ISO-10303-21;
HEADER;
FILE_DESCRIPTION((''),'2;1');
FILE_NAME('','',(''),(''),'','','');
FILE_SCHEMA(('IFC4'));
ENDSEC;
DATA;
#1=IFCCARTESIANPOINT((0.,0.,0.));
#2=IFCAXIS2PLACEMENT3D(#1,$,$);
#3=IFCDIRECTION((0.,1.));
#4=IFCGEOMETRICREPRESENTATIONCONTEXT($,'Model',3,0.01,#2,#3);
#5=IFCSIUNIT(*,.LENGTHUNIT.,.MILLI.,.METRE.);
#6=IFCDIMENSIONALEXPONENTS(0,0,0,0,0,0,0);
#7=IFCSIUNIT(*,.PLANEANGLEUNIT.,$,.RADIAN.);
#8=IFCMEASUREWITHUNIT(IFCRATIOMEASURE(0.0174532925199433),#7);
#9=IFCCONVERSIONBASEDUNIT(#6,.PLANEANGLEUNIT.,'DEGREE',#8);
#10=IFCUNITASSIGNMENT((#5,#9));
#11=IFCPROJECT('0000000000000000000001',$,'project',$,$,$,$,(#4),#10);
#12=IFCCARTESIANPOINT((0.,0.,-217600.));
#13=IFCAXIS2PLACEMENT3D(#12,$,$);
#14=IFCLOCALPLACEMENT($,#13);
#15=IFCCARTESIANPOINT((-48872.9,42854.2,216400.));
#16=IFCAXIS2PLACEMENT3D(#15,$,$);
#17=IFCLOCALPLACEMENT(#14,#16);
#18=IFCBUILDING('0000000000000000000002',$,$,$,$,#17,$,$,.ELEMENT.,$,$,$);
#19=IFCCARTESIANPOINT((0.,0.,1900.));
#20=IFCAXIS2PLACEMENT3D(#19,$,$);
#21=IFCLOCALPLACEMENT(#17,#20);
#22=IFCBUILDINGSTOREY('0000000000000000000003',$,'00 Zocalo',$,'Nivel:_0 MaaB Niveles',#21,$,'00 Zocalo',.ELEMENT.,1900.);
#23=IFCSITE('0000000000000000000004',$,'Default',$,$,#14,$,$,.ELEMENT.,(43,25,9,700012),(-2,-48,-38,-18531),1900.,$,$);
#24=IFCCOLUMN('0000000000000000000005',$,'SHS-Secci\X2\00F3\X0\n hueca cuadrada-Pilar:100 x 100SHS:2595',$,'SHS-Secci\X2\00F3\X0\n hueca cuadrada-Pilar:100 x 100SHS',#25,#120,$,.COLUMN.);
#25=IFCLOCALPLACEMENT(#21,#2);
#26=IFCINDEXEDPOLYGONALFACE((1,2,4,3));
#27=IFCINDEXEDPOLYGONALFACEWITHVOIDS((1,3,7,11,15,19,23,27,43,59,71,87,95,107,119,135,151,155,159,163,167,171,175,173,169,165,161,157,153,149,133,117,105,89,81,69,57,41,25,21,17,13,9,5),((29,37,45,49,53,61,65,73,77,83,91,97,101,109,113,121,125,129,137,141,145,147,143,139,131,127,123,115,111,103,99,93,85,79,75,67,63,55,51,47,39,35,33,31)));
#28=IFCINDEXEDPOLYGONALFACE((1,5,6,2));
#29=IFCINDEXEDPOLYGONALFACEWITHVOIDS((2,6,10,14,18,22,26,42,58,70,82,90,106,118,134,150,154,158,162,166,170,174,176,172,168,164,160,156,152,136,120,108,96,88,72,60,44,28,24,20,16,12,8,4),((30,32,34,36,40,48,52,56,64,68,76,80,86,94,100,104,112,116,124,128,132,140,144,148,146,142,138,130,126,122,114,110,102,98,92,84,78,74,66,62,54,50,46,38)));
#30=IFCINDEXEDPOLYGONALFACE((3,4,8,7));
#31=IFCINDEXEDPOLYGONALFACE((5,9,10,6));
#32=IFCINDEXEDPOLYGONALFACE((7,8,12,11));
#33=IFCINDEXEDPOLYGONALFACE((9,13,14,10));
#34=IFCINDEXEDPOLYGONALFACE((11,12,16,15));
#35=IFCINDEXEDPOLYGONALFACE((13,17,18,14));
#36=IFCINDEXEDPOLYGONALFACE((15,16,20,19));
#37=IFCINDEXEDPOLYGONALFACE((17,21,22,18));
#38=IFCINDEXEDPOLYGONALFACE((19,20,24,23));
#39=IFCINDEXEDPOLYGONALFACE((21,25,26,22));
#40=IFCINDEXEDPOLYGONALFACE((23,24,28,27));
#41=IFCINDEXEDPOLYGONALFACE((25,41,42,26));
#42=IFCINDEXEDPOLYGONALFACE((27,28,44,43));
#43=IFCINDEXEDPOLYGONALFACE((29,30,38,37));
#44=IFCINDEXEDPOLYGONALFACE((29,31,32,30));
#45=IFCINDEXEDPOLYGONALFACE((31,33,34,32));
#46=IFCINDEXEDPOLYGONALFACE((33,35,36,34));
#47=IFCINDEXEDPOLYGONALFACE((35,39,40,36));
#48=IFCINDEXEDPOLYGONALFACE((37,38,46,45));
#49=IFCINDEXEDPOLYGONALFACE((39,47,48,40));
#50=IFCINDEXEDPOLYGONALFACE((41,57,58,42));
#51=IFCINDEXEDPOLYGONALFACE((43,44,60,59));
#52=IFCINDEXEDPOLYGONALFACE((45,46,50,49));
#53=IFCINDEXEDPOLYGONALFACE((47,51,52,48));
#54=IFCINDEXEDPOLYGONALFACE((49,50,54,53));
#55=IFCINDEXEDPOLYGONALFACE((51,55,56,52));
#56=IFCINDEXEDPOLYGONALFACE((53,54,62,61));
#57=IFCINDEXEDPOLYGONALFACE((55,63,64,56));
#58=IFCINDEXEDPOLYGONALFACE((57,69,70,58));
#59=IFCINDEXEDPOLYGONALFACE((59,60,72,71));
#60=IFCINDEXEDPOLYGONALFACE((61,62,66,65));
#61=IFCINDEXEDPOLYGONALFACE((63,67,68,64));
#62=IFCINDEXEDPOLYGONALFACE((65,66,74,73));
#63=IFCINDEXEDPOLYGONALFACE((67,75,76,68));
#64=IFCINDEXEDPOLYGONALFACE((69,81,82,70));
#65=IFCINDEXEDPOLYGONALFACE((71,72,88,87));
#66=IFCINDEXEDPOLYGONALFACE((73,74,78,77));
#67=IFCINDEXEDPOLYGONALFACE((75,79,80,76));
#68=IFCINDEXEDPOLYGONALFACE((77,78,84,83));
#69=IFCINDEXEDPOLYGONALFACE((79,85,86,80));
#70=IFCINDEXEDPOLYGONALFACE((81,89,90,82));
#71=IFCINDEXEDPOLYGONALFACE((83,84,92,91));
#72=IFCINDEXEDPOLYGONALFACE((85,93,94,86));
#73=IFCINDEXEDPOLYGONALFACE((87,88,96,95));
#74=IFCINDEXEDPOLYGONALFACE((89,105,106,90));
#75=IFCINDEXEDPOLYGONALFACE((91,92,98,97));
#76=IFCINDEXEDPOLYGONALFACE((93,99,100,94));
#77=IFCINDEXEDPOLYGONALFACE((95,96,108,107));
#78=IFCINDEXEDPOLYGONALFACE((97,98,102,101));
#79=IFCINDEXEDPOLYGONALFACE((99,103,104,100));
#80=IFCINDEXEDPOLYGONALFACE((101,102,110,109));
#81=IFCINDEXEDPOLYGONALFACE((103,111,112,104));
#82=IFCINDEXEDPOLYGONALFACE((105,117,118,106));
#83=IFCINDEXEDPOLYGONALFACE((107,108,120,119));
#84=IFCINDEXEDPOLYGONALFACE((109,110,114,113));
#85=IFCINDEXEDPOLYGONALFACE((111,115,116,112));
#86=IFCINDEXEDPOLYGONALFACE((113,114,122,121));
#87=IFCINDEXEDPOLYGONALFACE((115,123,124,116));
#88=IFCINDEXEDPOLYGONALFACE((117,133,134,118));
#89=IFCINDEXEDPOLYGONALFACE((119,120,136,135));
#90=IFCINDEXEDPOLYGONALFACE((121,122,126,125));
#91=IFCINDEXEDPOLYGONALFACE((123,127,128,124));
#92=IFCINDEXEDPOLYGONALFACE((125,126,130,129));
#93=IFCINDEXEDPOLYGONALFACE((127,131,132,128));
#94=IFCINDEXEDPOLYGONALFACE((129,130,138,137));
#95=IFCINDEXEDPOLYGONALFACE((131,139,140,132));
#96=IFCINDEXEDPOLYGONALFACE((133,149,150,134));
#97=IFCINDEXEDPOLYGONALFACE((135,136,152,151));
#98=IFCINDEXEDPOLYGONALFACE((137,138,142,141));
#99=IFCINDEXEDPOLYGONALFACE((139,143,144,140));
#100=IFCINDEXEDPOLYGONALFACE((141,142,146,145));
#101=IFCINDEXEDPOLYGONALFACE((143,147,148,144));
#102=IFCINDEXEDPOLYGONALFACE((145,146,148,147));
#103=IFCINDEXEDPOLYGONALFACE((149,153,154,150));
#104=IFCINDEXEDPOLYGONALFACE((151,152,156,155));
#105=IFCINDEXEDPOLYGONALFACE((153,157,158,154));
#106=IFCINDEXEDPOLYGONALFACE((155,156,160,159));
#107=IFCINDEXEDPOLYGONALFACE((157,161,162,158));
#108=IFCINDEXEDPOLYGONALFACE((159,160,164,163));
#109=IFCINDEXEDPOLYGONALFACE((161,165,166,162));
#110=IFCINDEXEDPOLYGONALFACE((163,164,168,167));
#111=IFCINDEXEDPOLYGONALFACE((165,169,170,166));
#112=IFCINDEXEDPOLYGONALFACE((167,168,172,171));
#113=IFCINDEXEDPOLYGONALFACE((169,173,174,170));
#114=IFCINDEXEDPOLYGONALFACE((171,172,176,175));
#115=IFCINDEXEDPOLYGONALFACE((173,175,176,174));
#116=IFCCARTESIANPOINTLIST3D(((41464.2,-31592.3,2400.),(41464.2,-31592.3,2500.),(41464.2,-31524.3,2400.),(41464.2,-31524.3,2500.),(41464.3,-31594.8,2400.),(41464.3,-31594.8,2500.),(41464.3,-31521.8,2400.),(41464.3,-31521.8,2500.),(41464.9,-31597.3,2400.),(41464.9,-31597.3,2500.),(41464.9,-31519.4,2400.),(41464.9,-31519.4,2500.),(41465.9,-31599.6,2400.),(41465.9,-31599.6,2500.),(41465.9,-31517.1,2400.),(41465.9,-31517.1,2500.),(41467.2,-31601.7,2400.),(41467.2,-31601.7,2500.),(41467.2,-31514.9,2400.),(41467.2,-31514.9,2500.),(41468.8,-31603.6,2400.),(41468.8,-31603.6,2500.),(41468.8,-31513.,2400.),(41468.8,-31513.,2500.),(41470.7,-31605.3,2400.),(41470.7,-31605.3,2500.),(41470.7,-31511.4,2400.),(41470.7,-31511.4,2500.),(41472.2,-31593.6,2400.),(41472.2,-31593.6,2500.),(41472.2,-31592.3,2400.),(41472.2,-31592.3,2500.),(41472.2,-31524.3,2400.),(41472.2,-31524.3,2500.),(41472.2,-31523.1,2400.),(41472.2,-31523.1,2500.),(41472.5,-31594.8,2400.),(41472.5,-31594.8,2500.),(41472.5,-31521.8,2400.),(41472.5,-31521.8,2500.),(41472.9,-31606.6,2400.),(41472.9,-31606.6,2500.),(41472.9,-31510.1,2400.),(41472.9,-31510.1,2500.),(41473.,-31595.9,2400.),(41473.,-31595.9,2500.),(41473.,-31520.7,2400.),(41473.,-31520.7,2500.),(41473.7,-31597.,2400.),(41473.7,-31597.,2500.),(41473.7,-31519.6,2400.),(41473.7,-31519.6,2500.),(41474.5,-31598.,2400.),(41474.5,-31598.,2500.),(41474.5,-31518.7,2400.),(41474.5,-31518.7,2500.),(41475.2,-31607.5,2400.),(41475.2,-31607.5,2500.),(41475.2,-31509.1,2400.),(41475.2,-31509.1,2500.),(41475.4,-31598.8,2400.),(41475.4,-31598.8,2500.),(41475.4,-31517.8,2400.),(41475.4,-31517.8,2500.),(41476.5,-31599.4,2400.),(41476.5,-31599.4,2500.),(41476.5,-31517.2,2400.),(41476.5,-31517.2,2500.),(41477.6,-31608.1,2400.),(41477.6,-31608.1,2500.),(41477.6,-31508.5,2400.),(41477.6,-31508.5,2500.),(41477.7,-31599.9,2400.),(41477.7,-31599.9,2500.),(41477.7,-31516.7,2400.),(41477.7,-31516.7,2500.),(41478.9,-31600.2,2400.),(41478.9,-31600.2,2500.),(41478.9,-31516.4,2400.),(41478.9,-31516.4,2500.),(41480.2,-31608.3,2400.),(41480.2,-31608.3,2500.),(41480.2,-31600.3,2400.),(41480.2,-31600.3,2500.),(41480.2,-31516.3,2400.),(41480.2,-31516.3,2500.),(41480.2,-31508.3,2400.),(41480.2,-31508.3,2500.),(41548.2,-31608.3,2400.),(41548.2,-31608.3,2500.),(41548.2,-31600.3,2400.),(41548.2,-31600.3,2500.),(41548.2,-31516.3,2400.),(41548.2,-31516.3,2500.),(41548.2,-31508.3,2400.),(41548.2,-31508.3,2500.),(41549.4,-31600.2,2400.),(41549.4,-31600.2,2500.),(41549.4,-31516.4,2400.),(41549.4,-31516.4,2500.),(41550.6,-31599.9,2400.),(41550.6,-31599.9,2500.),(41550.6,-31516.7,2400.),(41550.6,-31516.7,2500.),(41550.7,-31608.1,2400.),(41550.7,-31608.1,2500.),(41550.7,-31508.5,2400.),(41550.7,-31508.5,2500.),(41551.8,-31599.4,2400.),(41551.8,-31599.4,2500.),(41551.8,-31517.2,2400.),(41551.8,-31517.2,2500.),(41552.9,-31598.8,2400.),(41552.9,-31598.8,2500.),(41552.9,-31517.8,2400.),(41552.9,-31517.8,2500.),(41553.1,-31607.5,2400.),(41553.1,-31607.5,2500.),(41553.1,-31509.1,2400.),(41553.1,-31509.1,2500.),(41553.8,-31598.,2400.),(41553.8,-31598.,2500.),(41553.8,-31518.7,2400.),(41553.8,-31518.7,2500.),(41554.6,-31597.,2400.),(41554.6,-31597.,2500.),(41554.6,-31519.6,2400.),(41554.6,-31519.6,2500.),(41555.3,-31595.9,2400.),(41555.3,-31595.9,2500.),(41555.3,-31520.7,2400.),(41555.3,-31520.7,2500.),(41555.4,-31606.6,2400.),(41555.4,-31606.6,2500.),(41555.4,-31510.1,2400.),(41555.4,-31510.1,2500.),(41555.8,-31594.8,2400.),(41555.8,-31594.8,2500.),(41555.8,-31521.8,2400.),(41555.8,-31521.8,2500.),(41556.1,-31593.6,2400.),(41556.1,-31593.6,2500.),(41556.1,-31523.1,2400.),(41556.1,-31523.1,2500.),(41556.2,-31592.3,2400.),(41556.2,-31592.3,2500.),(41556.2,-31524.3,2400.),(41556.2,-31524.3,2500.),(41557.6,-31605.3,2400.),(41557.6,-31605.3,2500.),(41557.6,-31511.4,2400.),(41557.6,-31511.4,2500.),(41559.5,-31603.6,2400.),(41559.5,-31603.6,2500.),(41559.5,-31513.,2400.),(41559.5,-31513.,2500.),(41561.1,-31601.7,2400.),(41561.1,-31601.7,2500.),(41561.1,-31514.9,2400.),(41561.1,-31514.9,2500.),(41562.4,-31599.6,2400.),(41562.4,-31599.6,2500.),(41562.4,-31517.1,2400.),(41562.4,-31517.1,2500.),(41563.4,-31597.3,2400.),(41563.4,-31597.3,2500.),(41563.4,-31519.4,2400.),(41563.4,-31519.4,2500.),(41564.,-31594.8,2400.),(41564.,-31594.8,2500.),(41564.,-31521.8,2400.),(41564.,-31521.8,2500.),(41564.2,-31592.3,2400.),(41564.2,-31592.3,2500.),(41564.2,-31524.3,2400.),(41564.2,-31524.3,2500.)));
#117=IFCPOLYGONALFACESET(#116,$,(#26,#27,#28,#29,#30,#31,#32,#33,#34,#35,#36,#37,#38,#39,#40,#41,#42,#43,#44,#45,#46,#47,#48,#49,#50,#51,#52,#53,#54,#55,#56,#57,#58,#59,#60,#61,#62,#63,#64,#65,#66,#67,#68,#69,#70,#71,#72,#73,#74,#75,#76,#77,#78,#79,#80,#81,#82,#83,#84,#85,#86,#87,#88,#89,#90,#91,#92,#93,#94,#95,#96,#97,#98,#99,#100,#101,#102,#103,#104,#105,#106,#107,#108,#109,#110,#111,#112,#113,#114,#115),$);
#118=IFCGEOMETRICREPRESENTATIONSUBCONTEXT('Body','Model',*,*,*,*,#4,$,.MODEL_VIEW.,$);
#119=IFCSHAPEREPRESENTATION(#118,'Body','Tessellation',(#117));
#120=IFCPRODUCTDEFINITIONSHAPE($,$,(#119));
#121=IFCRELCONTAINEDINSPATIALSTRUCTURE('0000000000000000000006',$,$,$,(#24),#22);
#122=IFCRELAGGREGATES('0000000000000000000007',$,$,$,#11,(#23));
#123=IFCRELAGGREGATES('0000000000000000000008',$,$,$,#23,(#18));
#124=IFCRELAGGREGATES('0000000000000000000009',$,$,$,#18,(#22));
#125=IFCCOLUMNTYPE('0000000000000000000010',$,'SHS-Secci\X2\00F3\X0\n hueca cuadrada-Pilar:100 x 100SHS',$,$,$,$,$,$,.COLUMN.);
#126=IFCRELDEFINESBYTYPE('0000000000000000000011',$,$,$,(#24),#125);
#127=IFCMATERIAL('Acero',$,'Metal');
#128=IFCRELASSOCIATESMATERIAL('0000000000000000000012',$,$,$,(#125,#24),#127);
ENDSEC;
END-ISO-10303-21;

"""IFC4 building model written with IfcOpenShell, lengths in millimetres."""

from ifc_helpers import new_model, entity, si_unit, converted_unit, direction, frame, origin, place, context, subcontext, project, spatial, indexed_curve, outline, extrude, source, transform, mapped, material, type_object, type_shapes, element, save


model = new_model("IFC4")

# Units and contexts
model_context = context("Model", 3, precision=0.01, world=origin(), true_north=direction((0.0, 1.0)))
body_context = subcontext(model_context, "Body", "Model", "MODEL_VIEW")
ifc_project = project(units=[si_unit("LENGTHUNIT", "METRE", prefix="MILLI"), converted_unit("PLANEANGLEUNIT", "DEGREE", entity("IfcRatioMeasure", 0.0174532925199433), si_unit("PLANEANGLEUNIT", "RADIAN"), dimensions=[0, 0, 0, 0, 0, 0, 0])], contexts=[model_context])

# Site, building, storey
site_placement = place(None, frame((0.0, 0.0, -217600.0)))
site = spatial("IfcSite", under=ifc_project, at=site_placement, Name="Default", CompositionType="ELEMENT", RefLatitude=(43, 25, 9, 700012), RefLongitude=(-2, -48, -38, -18531), RefElevation=1900.0)
building_placement = place(site_placement, frame((-48872.9, 42854.2, 216400.0)))
building = spatial("IfcBuilding", under=site, at=building_placement, CompositionType="ELEMENT")
storey_placement = place(building_placement, frame((0.0, 0.0, 1900.0)))
storey = spatial("IfcBuildingStorey", under=building, at=storey_placement, Name="00 Zocalo", ObjectType="Nivel:_0 MaaB Niveles", LongName="00 Zocalo", CompositionType="ELEMENT", Elevation=1900.0)

# Column
ifc_material = material(Name="Acero", Category="Metal")
column_type_1 = type_object("IfcColumnType", Name="SHS-Sección hueca cuadrada-Pilar:100 x 100SHS", PredefinedType="COLUMN", material=ifc_material)
shared_shape_1 = source(origin(), body_context, "Body", "SweptSolid", [
    extrude(outline(indexed_curve([(34.0, -50.0), (36.5, -49.8), (38.9, -49.2), (41.3, -48.3), (43.4, -46.9), (45.3, -45.3), (46.9, -43.4), (48.3, -41.3), (49.2, -38.9), (49.8, -36.5), (50.0, -34.0), (50.0, 34.0), (49.8, 36.5), (49.2, 38.9), (48.3, 41.3), (46.9, 43.4), (45.3, 45.3), (43.4, 46.9), (41.3, 48.3), (38.9, 49.2), (36.5, 49.8), (34.0, 50.0), (-34.0, 50.0), (-36.5, 49.8), (-38.9, 49.2), (-41.3, 48.3), (-43.4, 46.9), (-45.3, 45.3), (-46.9, 43.4), (-48.3, 41.3), (-49.2, 38.9), (-49.8, 36.5), (-50.0, 34.0), (-50.0, -34.0), (-49.8, -36.5), (-49.2, -38.9), (-48.3, -41.3), (-46.9, -43.4), (-45.3, -45.3), (-43.4, -46.9), (-41.3, -48.3), (-38.9, -49.2), (-36.5, -49.8), (-34.0, -50.0), (34.0, -50.0)], self_intersect=False), holes=[indexed_curve([(34.0, -42.0), (-34.0, -42.0), (-35.3, -41.9), (-36.5, -41.6), (-37.6, -41.1), (-38.7, -40.5), (-39.7, -39.7), (-40.5, -38.7), (-41.1, -37.6), (-41.6, -36.5), (-41.9, -35.3), (-42.0, -34.0), (-42.0, 34.0), (-41.9, 35.3), (-41.6, 36.5), (-41.1, 37.6), (-40.5, 38.7), (-39.7, 39.7), (-38.7, 40.5), (-37.6, 41.1), (-36.5, 41.6), (-35.3, 41.9), (-34.0, 42.0), (34.0, 42.0), (35.3, 41.9), (36.5, 41.6), (37.6, 41.1), (38.7, 40.5), (39.7, 39.7), (40.5, 38.7), (41.1, 37.6), (41.6, 36.5), (41.9, 35.3), (42.0, 34.0), (42.0, -34.0), (41.9, -35.3), (41.6, -36.5), (41.1, -37.6), (40.5, -38.7), (39.7, -39.7), (38.7, -40.5), (37.6, -41.1), (36.5, -41.6), (35.3, -41.9), (34.0, -42.0)], self_intersect=False)]), frame((0.0, 0.0, 4300.0)), (0.0, 0.0, 1.0), 100.0),
])
type_shapes(column_type_1, [shared_shape_1])
column_1_placement = place(storey_placement, frame((41514.2, -31558.3, -1900.0), z_axis=(0.0, 0.0, 1.0), x_axis=(0.0, -1.0, 0.0)))
element("IfcColumn", 1, at=column_1_placement, inside=storey, type_object=column_type_1, material=ifc_material, Name="SHS-Sección hueca cuadrada-Pilar:100 x 100SHS:2595", ObjectType="SHS-Sección hueca cuadrada-Pilar:100 x 100SHS", PredefinedType="COLUMN", context=body_context, shape_type="MappedRepresentation", body=[
    mapped(shared_shape_1, transform((0.0, 0.0, 0.0), scale=1.0)),
])

save(model, "model.ifc")
